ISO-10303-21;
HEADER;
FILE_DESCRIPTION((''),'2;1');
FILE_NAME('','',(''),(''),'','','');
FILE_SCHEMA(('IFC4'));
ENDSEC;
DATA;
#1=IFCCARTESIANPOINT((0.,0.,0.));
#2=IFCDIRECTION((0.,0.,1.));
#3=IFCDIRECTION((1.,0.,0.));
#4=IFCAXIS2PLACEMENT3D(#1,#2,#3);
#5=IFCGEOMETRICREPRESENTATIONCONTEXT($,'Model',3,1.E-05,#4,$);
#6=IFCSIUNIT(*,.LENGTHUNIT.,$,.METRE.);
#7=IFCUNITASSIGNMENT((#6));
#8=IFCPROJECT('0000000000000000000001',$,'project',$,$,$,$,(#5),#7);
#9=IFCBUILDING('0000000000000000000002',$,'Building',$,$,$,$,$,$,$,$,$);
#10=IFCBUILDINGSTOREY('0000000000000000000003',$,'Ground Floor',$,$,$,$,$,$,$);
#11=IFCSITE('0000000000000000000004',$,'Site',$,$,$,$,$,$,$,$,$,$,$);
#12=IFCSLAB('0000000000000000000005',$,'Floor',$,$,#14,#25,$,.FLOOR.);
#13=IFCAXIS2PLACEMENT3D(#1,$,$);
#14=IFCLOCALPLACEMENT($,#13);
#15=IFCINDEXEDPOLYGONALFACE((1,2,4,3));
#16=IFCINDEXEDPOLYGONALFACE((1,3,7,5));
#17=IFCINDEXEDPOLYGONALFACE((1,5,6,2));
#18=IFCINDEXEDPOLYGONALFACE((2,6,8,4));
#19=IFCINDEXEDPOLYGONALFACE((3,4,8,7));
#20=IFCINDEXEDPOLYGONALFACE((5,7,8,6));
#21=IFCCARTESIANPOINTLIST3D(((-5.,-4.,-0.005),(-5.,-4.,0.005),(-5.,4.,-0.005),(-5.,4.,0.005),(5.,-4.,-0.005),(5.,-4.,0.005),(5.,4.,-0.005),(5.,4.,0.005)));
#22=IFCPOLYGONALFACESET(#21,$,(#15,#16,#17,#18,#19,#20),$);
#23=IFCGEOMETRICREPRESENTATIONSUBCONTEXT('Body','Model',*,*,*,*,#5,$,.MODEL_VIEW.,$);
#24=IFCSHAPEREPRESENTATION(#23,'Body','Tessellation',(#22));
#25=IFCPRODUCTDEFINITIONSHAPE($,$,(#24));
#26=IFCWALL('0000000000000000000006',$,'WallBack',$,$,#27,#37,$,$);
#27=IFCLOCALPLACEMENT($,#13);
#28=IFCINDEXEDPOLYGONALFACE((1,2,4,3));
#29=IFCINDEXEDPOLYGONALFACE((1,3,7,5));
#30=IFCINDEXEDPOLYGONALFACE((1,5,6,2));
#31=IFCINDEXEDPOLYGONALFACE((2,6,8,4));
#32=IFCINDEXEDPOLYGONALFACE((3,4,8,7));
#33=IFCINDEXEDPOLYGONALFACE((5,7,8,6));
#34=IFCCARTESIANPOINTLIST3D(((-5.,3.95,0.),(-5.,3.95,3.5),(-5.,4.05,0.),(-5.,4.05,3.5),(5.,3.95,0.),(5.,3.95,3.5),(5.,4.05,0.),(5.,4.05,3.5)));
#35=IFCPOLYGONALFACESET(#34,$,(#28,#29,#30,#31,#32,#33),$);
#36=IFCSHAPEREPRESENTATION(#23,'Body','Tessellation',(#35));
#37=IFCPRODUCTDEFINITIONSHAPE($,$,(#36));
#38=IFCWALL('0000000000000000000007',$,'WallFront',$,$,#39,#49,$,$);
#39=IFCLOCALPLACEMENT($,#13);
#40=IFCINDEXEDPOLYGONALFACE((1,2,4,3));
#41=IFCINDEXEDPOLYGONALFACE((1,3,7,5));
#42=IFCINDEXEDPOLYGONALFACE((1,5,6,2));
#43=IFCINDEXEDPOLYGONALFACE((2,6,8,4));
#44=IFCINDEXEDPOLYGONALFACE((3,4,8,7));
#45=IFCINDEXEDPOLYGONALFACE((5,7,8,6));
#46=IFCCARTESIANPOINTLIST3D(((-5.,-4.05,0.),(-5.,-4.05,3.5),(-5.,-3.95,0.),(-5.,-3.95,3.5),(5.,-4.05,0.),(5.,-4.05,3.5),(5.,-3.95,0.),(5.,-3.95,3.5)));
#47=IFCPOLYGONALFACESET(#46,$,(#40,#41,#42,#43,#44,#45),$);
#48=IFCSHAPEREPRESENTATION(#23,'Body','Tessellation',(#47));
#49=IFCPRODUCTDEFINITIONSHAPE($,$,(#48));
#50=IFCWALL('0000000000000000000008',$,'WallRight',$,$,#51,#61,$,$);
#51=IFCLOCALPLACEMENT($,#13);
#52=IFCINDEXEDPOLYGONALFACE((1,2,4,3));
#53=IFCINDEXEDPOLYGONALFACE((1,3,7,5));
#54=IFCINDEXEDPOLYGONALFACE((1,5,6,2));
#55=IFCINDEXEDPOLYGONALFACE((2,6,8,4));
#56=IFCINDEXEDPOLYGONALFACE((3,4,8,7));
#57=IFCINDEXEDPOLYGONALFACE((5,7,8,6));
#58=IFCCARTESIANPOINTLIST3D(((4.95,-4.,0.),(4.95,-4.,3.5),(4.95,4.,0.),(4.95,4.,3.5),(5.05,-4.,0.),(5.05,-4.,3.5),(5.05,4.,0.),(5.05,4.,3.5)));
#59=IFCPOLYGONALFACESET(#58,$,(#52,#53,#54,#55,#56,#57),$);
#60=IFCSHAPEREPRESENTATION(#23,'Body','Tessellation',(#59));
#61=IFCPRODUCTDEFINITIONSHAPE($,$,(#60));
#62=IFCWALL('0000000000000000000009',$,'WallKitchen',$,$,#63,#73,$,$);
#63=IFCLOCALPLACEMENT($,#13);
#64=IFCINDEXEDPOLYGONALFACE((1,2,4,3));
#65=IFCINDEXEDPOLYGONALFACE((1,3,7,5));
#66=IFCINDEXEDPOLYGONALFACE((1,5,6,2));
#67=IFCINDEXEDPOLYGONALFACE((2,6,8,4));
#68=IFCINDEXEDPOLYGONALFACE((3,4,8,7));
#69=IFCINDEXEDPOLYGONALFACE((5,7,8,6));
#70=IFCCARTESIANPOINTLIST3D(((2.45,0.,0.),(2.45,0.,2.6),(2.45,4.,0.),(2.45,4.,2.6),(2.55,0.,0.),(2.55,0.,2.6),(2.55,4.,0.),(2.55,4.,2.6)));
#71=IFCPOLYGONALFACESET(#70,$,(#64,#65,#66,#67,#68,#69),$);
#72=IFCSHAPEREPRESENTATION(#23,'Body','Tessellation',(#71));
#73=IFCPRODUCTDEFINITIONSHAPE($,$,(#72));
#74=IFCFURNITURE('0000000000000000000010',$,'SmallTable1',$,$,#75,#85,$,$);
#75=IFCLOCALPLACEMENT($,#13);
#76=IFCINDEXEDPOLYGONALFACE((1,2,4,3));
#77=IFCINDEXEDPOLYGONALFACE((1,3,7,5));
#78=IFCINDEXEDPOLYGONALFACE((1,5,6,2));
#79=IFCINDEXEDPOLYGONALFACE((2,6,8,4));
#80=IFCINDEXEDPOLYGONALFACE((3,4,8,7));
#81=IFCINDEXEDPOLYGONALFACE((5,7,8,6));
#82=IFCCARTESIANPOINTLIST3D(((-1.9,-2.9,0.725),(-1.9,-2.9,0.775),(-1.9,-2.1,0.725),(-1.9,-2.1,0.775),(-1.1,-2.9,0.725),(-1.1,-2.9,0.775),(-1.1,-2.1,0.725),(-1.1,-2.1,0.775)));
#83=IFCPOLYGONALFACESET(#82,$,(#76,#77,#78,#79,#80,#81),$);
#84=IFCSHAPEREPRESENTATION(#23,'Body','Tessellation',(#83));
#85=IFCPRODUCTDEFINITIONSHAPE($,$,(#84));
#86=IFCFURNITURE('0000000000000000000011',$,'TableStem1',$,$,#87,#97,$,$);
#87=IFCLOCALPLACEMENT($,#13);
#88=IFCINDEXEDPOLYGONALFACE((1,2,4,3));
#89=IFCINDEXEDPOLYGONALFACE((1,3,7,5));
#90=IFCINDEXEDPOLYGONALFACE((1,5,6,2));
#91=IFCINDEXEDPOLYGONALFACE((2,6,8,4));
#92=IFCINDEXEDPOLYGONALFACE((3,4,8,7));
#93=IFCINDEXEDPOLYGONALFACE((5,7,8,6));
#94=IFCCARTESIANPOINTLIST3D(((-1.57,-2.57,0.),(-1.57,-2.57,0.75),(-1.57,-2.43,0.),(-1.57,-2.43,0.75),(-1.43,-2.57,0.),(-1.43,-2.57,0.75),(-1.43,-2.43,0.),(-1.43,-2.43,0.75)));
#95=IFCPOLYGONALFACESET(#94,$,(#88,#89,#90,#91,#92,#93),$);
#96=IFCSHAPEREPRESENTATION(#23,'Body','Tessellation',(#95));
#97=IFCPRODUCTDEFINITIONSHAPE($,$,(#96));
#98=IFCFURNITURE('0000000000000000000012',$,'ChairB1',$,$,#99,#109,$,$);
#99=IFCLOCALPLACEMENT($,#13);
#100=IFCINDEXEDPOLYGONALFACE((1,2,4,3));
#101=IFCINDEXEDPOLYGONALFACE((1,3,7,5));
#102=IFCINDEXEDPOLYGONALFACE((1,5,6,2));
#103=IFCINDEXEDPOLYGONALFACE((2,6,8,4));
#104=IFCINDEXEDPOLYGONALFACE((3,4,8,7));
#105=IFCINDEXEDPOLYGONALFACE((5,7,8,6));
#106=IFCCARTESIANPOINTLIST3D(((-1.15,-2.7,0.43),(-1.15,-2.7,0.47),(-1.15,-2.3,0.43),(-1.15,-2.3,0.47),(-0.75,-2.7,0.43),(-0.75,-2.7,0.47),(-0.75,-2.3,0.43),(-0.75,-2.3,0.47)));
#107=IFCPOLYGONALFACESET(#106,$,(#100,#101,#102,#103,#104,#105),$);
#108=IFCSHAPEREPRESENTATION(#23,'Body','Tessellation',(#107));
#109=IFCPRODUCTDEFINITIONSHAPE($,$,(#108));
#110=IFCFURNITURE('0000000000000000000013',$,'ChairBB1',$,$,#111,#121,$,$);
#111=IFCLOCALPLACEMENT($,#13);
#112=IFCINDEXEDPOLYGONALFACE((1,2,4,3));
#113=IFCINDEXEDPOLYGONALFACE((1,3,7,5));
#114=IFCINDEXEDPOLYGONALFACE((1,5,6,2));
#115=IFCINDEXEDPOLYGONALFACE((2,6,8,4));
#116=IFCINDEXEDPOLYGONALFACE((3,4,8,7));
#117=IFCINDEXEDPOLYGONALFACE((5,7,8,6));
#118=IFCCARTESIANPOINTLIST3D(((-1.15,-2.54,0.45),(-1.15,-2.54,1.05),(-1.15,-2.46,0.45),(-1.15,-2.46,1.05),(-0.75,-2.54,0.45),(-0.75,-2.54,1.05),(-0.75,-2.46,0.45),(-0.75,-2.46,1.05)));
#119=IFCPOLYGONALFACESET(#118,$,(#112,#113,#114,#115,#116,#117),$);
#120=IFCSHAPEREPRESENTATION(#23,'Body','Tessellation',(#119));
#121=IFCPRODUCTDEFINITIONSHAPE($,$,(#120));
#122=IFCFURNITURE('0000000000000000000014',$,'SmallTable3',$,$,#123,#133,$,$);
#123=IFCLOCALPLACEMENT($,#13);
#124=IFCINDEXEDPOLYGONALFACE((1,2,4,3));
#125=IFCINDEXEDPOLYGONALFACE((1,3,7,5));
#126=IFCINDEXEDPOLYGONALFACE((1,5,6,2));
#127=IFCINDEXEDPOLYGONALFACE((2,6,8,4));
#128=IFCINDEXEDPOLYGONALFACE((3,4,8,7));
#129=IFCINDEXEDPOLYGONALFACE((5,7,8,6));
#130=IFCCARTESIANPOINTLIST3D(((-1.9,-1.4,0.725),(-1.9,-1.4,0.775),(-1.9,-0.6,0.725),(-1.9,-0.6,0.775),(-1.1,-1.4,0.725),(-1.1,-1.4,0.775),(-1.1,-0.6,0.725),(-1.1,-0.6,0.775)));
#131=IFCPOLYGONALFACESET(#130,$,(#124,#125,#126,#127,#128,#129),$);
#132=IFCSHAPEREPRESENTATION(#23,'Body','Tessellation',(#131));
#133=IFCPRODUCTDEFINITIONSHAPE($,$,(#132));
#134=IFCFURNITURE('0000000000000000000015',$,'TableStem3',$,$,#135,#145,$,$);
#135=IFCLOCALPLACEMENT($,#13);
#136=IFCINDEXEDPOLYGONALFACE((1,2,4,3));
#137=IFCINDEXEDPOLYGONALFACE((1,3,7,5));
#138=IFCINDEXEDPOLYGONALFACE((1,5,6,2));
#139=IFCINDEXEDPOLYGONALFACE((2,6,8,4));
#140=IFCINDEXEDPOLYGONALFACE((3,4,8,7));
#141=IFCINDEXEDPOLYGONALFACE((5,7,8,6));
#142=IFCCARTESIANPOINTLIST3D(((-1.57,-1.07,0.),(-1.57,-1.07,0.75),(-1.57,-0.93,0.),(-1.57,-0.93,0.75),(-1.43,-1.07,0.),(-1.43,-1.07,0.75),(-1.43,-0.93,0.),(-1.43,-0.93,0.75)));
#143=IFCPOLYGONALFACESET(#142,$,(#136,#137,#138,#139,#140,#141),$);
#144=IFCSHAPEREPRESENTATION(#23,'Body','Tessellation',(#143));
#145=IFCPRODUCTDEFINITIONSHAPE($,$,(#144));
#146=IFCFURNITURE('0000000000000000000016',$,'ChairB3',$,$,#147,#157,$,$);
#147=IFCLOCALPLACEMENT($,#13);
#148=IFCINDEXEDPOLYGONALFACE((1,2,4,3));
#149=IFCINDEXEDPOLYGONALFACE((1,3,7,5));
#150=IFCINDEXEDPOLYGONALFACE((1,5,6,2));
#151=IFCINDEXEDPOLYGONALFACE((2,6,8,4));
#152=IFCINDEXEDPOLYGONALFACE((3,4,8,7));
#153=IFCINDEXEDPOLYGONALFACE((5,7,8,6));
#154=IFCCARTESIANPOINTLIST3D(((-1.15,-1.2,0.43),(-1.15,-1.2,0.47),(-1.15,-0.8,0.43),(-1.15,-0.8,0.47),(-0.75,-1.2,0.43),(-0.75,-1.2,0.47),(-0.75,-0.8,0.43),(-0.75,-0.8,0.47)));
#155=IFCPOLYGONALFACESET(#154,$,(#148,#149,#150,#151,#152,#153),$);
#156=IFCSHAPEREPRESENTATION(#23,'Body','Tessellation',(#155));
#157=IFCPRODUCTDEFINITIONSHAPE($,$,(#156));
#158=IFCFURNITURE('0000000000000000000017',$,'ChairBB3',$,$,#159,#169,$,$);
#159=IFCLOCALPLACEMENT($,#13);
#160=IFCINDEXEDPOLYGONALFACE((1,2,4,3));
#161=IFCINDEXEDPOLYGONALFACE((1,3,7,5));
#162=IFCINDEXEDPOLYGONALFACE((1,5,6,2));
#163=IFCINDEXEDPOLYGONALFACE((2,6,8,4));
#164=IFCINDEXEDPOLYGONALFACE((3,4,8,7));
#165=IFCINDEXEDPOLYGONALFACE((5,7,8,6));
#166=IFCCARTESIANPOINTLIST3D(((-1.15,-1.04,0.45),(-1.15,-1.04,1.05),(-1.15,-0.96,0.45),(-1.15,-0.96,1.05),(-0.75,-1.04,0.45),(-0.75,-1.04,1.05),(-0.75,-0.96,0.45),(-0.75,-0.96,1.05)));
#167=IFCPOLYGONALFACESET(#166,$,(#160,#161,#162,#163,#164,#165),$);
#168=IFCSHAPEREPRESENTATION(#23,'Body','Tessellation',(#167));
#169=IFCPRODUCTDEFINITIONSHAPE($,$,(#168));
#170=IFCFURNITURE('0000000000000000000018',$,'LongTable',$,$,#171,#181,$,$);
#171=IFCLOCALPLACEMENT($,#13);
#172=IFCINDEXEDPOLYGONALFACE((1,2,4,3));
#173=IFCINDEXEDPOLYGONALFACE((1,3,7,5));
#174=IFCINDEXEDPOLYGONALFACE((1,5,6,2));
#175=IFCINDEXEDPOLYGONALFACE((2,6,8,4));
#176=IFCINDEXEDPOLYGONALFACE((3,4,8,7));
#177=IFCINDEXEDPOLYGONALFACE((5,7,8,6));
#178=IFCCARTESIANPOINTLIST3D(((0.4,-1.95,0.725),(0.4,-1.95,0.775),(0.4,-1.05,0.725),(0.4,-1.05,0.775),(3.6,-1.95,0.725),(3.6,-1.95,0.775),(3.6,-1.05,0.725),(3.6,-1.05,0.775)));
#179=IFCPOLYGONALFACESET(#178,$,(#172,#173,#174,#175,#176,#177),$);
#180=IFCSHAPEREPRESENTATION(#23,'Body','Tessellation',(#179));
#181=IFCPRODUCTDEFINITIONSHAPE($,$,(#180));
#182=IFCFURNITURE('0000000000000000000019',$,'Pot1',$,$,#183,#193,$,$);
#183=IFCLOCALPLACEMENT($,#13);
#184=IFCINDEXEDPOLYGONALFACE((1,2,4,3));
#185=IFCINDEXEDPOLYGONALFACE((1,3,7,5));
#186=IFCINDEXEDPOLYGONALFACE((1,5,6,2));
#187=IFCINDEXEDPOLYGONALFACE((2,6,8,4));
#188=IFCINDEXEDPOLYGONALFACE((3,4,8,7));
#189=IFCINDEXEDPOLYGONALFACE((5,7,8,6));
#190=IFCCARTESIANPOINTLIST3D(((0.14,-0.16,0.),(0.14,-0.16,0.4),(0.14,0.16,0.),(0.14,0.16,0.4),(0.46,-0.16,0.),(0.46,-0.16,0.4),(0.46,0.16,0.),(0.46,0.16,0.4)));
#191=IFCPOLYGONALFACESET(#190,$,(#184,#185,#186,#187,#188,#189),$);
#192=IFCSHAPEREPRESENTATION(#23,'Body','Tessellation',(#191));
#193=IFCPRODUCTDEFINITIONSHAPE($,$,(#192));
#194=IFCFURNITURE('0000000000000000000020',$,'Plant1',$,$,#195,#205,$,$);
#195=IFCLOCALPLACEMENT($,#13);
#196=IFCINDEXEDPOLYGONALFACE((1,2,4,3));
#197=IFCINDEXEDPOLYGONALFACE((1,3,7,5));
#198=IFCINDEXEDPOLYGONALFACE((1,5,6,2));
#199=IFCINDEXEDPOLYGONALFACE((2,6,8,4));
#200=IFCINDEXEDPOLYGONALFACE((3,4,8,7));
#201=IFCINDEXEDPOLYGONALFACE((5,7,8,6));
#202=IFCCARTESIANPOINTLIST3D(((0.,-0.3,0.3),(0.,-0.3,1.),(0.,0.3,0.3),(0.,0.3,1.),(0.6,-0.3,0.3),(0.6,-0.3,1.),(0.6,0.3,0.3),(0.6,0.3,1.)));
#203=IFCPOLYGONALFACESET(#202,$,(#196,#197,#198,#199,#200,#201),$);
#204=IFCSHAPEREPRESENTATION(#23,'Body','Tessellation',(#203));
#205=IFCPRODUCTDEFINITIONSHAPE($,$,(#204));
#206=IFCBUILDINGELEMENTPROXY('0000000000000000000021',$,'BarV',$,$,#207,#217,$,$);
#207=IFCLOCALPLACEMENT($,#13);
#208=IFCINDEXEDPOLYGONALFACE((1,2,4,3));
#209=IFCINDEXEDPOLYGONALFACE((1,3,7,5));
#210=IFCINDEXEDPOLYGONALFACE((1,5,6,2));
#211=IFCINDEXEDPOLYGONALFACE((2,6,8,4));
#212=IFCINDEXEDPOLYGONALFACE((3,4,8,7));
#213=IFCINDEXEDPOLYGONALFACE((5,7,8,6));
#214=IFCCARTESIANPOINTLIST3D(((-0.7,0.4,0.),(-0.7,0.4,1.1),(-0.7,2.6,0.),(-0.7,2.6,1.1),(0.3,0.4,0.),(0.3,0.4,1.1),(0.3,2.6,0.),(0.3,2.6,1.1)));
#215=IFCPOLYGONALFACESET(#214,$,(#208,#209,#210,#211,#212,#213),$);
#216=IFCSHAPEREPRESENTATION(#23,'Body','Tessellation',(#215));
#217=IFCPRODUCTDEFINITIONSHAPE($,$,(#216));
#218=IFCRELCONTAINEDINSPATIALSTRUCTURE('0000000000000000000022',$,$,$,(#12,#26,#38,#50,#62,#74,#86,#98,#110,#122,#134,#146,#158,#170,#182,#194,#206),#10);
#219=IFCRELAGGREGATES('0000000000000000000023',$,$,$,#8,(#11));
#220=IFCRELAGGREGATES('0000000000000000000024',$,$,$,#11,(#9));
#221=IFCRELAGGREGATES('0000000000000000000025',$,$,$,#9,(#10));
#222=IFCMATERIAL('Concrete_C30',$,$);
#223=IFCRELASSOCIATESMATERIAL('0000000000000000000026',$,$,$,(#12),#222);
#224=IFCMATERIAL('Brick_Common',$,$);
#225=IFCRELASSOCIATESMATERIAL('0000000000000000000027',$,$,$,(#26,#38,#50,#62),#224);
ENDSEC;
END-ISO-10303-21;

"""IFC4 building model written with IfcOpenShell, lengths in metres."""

from ifc_helpers import new_model, si_unit, frame, origin_with_axes, origin_2d, place, context, subcontext, project, spatial, rectangle, extrude, material, element, save


model = new_model("IFC4")

# Units and contexts
model_context = context("Model", 3, precision=1e-05, world=origin_with_axes())
body_context = subcontext(model_context, "Body", "Model", "MODEL_VIEW")
ifc_project = project(units=[si_unit("LENGTHUNIT", "METRE")], contexts=[model_context])

# Site, building, storey
site = spatial("IfcSite", under=ifc_project, Name="Site")
building = spatial("IfcBuilding", under=site, Name="Building")
storey = spatial("IfcBuildingStorey", under=building, Name="Ground Floor")

# Slab
ifc_material_1 = material(Name="Concrete_C30")
slab_placement = place(None, origin_with_axes())
element("IfcSlab", 1, at=slab_placement, inside=storey, material=ifc_material_1, Name="Floor", PredefinedType="FLOOR", context=body_context, shape_type="SweptSolid", body=[
    extrude(rectangle(XDim=10.0, YDim=8.0, at=origin_2d()), frame((0.0, 0.0, -0.005)), (0.0, 0.0, 1.0), 0.01),
])

# Walls
ifc_material_2 = material(Name="Brick_Common")
for number, where, z_axis, x_axis, name in (
    (2, (0.0, 4.0, 1.75), (0.0, 0.0, 1.0), (1.0, 0.0, 0.0), "WallBack"),
    (3, (0.0, -4.0, 1.75), (0.0, 0.0, 1.0), (1.0, 0.0, 0.0), "WallFront"),
):
    element("IfcWall", number, at=place(None, frame(where, z_axis=z_axis, x_axis=x_axis)), inside=storey, material=ifc_material_2, Name=name, context=body_context, shape_type="SweptSolid", body=[
        extrude(rectangle(XDim=10.0, YDim=0.1, at=origin_2d()), frame((0.0, 0.0, -1.75)), (0.0, 0.0, 1.0), 3.5),
    ])
wall_1_placement = place(None, frame((5.0, 0.0, 1.75), z_axis=(0.0, 0.0, 1.0), x_axis=(1.0, 0.0, 0.0)))
element("IfcWall", 4, at=wall_1_placement, inside=storey, material=ifc_material_2, Name="WallRight", context=body_context, shape_type="SweptSolid", body=[
    extrude(rectangle(XDim=0.1, YDim=8.0, at=origin_2d()), frame((0.0, 0.0, -1.75)), (0.0, 0.0, 1.0), 3.5),
])
wall_2_placement = place(None, frame((2.5, 2.0, 1.3), z_axis=(0.0, 0.0, 1.0), x_axis=(1.0, 0.0, 0.0)))
element("IfcWall", 5, at=wall_2_placement, inside=storey, material=ifc_material_2, Name="WallKitchen", context=body_context, shape_type="SweptSolid", body=[
    extrude(rectangle(XDim=0.1, YDim=4.0, at=origin_2d()), frame((0.0, 0.0, -1.3)), (0.0, 0.0, 1.0), 2.6),
])

# Furniture
furniture_1_placement = place(None, frame((-1.5, -2.5, 0.75), z_axis=(0.0, 0.0, 1.0), x_axis=(1.0, 0.0, 0.0)))
element("IfcFurniture", 6, at=furniture_1_placement, inside=storey, Name="SmallTable1", context=body_context, shape_type="SweptSolid", body=[
    extrude(rectangle(XDim=0.8, YDim=0.8, at=origin_2d()), frame((0.0, 0.0, -0.025)), (0.0, 0.0, 1.0), 0.05),
])
furniture_2_placement = place(None, frame((-1.5, -2.5, 0.375), z_axis=(0.0, 0.0, 1.0), x_axis=(1.0, 0.0, 0.0)))
element("IfcFurniture", 7, at=furniture_2_placement, inside=storey, Name="TableStem1", context=body_context, shape_type="SweptSolid", body=[
    extrude(rectangle(XDim=0.14, YDim=0.14, at=origin_2d()), frame((0.0, 0.0, -0.375)), (0.0, 0.0, 1.0), 0.75),
])
furniture_3_placement = place(None, frame((-0.95, -2.5, 0.45), z_axis=(0.0, 0.0, 1.0), x_axis=(1.0, 0.0, 0.0)))
element("IfcFurniture", 8, at=furniture_3_placement, inside=storey, Name="ChairB1", context=body_context, shape_type="SweptSolid", body=[
    extrude(rectangle(XDim=0.4, YDim=0.4, at=origin_2d()), frame((0.0, 0.0, -0.02)), (0.0, 0.0, 1.0), 0.04),
])
furniture_4_placement = place(None, frame((-0.95, -2.5, 0.75), z_axis=(0.0, 0.0, 1.0), x_axis=(1.0, 0.0, 0.0)))
element("IfcFurniture", 9, at=furniture_4_placement, inside=storey, Name="ChairBB1", context=body_context, shape_type="SweptSolid", body=[
    extrude(rectangle(XDim=0.4, YDim=0.08, at=origin_2d()), frame((0.0, 0.0, -0.3)), (0.0, 0.0, 1.0), 0.6),
])
furniture_5_placement = place(None, frame((-1.5, -1.0, 0.75), z_axis=(0.0, 0.0, 1.0), x_axis=(1.0, 0.0, 0.0)))
element("IfcFurniture", 10, at=furniture_5_placement, inside=storey, Name="SmallTable3", context=body_context, shape_type="SweptSolid", body=[
    extrude(rectangle(XDim=0.8, YDim=0.8, at=origin_2d()), frame((0.0, 0.0, -0.025)), (0.0, 0.0, 1.0), 0.05),
])
furniture_6_placement = place(None, frame((-1.5, -1.0, 0.375), z_axis=(0.0, 0.0, 1.0), x_axis=(1.0, 0.0, 0.0)))
element("IfcFurniture", 11, at=furniture_6_placement, inside=storey, Name="TableStem3", context=body_context, shape_type="SweptSolid", body=[
    extrude(rectangle(XDim=0.14, YDim=0.14, at=origin_2d()), frame((0.0, 0.0, -0.375)), (0.0, 0.0, 1.0), 0.75),
])
furniture_7_placement = place(None, frame((-0.95, -1.0, 0.45), z_axis=(0.0, 0.0, 1.0), x_axis=(1.0, 0.0, 0.0)))
element("IfcFurniture", 12, at=furniture_7_placement, inside=storey, Name="ChairB3", context=body_context, shape_type="SweptSolid", body=[
    extrude(rectangle(XDim=0.4, YDim=0.4, at=origin_2d()), frame((0.0, 0.0, -0.02)), (0.0, 0.0, 1.0), 0.04),
])
furniture_8_placement = place(None, frame((-0.95, -1.0, 0.75), z_axis=(0.0, 0.0, 1.0), x_axis=(1.0, 0.0, 0.0)))
element("IfcFurniture", 13, at=furniture_8_placement, inside=storey, Name="ChairBB3", context=body_context, shape_type="SweptSolid", body=[
    extrude(rectangle(XDim=0.4, YDim=0.08, at=origin_2d()), frame((0.0, 0.0, -0.3)), (0.0, 0.0, 1.0), 0.6),
])
furniture_9_placement = place(None, frame((2.0, -1.5, 0.75), z_axis=(0.0, 0.0, 1.0), x_axis=(1.0, 0.0, 0.0)))
element("IfcFurniture", 14, at=furniture_9_placement, inside=storey, Name="LongTable", context=body_context, shape_type="SweptSolid", body=[
    extrude(rectangle(XDim=3.2, YDim=0.9, at=origin_2d()), frame((0.0, 0.0, -0.025)), (0.0, 0.0, 1.0), 0.05),
])
furniture_10_placement = place(None, frame((0.3, 0.0, 0.2), z_axis=(0.0, 0.0, 1.0), x_axis=(1.0, 0.0, 0.0)))
element("IfcFurniture", 15, at=furniture_10_placement, inside=storey, Name="Pot1", context=body_context, shape_type="SweptSolid", body=[
    extrude(rectangle(XDim=0.32, YDim=0.32, at=origin_2d()), frame((0.0, 0.0, -0.2)), (0.0, 0.0, 1.0), 0.4),
])
furniture_11_placement = place(None, frame((0.3, 0.0, 0.65), z_axis=(0.0, 0.0, 1.0), x_axis=(1.0, 0.0, 0.0)))
element("IfcFurniture", 16, at=furniture_11_placement, inside=storey, Name="Plant1", context=body_context, shape_type="SweptSolid", body=[
    extrude(rectangle(XDim=0.6, YDim=0.6, at=origin_2d()), frame((0.0, 0.0, -0.35)), (0.0, 0.0, 1.0), 0.7),
])

# Building element proxy
proxy_1_placement = place(None, frame((-0.2, 1.5, 0.55), z_axis=(0.0, 0.0, 1.0), x_axis=(1.0, 0.0, 0.0)))
element("IfcBuildingElementProxy", 17, at=proxy_1_placement, inside=storey, Name="BarV", context=body_context, shape_type="SweptSolid", body=[
    extrude(rectangle(XDim=1.0, YDim=2.2, at=origin_2d()), frame((0.0, 0.0, -0.55)), (0.0, 0.0, 1.0), 1.1),
])

save(model, "model.ifc")
